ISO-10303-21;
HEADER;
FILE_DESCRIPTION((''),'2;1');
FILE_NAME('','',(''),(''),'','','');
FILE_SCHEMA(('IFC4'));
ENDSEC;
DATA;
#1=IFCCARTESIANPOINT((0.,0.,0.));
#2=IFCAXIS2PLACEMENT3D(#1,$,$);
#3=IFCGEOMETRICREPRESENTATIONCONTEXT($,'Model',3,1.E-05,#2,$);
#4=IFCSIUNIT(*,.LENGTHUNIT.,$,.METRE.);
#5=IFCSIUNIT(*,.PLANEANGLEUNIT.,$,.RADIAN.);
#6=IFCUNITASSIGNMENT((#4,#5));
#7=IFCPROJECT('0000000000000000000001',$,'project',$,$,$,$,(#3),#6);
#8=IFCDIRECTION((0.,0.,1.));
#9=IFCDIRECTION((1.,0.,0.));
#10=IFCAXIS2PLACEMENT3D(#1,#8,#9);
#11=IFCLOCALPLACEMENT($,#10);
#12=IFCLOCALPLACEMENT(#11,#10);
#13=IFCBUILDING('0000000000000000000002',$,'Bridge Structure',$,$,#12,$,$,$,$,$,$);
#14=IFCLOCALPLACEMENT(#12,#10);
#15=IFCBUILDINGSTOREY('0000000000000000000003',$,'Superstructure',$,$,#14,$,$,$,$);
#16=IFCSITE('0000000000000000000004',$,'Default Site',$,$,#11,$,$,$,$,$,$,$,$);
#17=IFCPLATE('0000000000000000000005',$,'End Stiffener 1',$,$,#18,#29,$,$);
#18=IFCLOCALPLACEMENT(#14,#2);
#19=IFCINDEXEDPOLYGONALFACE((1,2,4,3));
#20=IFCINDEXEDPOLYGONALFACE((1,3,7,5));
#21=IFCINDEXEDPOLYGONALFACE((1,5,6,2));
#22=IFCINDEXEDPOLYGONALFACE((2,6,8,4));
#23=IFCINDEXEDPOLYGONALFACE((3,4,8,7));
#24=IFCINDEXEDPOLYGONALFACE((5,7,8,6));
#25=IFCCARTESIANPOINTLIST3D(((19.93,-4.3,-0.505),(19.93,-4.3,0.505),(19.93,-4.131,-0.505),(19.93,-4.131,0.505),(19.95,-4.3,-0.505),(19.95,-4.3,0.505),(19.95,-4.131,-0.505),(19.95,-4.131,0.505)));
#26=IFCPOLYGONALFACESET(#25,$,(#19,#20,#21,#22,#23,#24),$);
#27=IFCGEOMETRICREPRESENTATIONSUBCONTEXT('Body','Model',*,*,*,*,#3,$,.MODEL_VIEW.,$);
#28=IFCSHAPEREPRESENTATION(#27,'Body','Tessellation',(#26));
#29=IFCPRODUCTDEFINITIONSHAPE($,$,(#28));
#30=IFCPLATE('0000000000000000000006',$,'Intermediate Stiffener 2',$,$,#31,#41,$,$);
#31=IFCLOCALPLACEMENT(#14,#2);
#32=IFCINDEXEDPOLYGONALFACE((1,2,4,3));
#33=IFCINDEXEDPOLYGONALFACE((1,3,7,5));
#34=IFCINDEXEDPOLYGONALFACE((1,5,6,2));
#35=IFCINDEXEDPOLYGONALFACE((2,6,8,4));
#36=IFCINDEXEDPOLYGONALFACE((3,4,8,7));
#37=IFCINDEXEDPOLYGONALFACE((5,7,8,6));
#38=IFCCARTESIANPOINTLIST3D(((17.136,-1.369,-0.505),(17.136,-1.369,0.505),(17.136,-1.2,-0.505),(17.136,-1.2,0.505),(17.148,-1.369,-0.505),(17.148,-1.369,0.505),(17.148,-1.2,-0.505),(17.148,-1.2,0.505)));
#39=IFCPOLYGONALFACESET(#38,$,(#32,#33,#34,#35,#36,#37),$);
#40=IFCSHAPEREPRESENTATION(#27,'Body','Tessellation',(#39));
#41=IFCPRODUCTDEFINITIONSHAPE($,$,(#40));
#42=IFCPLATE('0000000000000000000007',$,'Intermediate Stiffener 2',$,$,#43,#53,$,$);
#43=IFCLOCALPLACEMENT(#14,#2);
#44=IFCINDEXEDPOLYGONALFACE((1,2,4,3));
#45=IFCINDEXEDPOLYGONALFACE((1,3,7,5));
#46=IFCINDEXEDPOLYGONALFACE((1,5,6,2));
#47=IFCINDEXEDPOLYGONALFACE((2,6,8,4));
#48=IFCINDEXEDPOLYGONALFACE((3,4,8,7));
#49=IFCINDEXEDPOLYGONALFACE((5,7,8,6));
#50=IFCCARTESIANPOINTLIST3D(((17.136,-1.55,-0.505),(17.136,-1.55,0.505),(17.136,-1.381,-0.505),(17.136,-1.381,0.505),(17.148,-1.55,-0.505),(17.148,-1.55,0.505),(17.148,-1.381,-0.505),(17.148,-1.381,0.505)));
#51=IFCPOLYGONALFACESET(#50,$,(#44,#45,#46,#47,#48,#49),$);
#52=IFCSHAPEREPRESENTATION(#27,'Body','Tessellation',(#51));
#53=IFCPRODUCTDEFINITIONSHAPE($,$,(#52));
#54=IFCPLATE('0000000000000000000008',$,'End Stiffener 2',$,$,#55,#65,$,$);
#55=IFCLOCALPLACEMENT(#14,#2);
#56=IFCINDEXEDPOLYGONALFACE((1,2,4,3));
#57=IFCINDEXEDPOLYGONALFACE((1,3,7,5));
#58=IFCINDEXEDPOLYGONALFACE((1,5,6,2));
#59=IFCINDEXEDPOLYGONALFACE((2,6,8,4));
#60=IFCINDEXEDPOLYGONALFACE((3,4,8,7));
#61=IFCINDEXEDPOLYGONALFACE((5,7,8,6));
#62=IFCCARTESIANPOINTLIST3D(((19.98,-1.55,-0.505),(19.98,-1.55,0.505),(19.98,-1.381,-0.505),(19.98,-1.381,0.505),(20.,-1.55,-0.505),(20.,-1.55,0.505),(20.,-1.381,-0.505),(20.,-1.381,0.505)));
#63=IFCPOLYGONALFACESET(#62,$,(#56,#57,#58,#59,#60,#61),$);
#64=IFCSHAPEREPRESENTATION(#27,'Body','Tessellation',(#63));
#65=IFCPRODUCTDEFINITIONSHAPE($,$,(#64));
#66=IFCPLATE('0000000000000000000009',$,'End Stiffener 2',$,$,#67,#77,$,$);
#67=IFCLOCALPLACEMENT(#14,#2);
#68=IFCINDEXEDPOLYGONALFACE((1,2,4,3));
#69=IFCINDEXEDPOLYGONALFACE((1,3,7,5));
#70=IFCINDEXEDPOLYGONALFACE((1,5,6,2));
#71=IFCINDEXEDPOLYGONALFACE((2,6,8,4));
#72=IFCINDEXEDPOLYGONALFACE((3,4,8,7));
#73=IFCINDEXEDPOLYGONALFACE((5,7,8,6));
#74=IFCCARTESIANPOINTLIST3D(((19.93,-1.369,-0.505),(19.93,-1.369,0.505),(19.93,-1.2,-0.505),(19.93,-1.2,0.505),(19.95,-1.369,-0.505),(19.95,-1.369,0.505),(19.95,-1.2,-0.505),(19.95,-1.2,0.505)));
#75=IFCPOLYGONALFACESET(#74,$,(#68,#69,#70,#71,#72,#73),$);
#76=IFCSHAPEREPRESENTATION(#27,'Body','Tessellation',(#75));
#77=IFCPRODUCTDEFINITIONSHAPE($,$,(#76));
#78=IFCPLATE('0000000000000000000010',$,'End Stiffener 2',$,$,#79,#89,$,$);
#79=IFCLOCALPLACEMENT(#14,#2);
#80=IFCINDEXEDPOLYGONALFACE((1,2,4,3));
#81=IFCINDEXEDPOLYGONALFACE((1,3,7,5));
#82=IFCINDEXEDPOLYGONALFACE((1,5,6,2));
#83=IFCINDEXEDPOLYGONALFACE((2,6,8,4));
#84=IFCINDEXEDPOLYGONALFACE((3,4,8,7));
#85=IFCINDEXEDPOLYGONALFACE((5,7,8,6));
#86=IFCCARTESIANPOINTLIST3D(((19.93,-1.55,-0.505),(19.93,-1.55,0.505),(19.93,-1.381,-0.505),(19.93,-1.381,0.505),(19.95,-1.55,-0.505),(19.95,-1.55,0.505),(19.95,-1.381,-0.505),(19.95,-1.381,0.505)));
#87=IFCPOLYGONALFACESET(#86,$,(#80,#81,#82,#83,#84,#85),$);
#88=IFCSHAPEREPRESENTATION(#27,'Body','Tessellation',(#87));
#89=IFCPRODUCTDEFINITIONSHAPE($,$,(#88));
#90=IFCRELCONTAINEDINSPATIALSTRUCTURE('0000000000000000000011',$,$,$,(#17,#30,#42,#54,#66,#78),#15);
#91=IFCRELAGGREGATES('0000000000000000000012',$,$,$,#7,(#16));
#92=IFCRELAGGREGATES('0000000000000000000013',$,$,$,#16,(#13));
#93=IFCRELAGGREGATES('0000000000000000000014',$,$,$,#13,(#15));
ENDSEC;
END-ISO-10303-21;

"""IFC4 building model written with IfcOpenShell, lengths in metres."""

from ifc_helpers import new_model, si_unit, frame, origin, origin_with_axes, origin_2d_with_axis, place, context, subcontext, project, spatial, rectangle, extrude, element, save


model = new_model("IFC4")

# Units and contexts
model_context = context("Model", 3, precision=1e-05, world=origin())
body_context = subcontext(model_context, "Body", "Model", "MODEL_VIEW")
ifc_project = project(units=[si_unit("LENGTHUNIT", "METRE"), si_unit("PLANEANGLEUNIT", "RADIAN")], contexts=[model_context])

# Site, building, storey
site_placement = place(None, origin_with_axes())
site = spatial("IfcSite", under=ifc_project, at=site_placement, Name="Default Site")
building_placement = place(site_placement, origin_with_axes())
building = spatial("IfcBuilding", under=site, at=building_placement, Name="Bridge Structure")
storey_placement = place(building_placement, origin_with_axes())
storey = spatial("IfcBuildingStorey", under=building, at=storey_placement, Name="Superstructure")

# Plates
for number, where, z_axis, x_axis, name in (
    (1, (19.94, -4.2155, -0.505), (0.0, 0.0, 1.0), (1.0, 0.0, 0.0), "End Stiffener 1"),
):
    element("IfcPlate", number, at=place(storey_placement, frame(where, z_axis=z_axis, x_axis=x_axis)), inside=storey, Name=name, context=body_context, shape_type="SweptSolid", body=[
        extrude(rectangle(XDim=0.02, YDim=0.169, at=origin_2d_with_axis()), origin_with_axes(), (0.0, 0.0, 1.0), 1.01),
    ])
for number, where, z_axis, x_axis, name in (
    (2, (17.142, -1.2845, -0.505), (0.0, 0.0, 1.0), (1.0, 0.0, 0.0), "Intermediate Stiffener 2"),
    (3, (17.142, -1.4655, -0.505), (0.0, 0.0, 1.0), (1.0, 0.0, 0.0), "Intermediate Stiffener 2"),
):
    element("IfcPlate", number, at=place(storey_placement, frame(where, z_axis=z_axis, x_axis=x_axis)), inside=storey, Name=name, context=body_context, shape_type="SweptSolid", body=[
        extrude(rectangle(XDim=0.012, YDim=0.169, at=origin_2d_with_axis()), origin_with_axes(), (0.0, 0.0, 1.0), 1.01),
    ])
for number, where, z_axis, x_axis, name in (
    (4, (19.99, -1.4655, -0.505), (0.0, 0.0, 1.0), (1.0, 0.0, 0.0), "End Stiffener 2"),
    (5, (19.94, -1.2845, -0.505), (0.0, 0.0, 1.0), (1.0, 0.0, 0.0), "End Stiffener 2"),
    (6, (19.94, -1.4655, -0.505), (0.0, 0.0, 1.0), (1.0, 0.0, 0.0), "End Stiffener 2"),
):
    element("IfcPlate", number, at=place(storey_placement, frame(where, z_axis=z_axis, x_axis=x_axis)), inside=storey, Name=name, context=body_context, shape_type="SweptSolid", body=[
        extrude(rectangle(XDim=0.02, YDim=0.169, at=origin_2d_with_axis()), origin_with_axes(), (0.0, 0.0, 1.0), 1.01),
    ])

save(model, "model.ifc")
